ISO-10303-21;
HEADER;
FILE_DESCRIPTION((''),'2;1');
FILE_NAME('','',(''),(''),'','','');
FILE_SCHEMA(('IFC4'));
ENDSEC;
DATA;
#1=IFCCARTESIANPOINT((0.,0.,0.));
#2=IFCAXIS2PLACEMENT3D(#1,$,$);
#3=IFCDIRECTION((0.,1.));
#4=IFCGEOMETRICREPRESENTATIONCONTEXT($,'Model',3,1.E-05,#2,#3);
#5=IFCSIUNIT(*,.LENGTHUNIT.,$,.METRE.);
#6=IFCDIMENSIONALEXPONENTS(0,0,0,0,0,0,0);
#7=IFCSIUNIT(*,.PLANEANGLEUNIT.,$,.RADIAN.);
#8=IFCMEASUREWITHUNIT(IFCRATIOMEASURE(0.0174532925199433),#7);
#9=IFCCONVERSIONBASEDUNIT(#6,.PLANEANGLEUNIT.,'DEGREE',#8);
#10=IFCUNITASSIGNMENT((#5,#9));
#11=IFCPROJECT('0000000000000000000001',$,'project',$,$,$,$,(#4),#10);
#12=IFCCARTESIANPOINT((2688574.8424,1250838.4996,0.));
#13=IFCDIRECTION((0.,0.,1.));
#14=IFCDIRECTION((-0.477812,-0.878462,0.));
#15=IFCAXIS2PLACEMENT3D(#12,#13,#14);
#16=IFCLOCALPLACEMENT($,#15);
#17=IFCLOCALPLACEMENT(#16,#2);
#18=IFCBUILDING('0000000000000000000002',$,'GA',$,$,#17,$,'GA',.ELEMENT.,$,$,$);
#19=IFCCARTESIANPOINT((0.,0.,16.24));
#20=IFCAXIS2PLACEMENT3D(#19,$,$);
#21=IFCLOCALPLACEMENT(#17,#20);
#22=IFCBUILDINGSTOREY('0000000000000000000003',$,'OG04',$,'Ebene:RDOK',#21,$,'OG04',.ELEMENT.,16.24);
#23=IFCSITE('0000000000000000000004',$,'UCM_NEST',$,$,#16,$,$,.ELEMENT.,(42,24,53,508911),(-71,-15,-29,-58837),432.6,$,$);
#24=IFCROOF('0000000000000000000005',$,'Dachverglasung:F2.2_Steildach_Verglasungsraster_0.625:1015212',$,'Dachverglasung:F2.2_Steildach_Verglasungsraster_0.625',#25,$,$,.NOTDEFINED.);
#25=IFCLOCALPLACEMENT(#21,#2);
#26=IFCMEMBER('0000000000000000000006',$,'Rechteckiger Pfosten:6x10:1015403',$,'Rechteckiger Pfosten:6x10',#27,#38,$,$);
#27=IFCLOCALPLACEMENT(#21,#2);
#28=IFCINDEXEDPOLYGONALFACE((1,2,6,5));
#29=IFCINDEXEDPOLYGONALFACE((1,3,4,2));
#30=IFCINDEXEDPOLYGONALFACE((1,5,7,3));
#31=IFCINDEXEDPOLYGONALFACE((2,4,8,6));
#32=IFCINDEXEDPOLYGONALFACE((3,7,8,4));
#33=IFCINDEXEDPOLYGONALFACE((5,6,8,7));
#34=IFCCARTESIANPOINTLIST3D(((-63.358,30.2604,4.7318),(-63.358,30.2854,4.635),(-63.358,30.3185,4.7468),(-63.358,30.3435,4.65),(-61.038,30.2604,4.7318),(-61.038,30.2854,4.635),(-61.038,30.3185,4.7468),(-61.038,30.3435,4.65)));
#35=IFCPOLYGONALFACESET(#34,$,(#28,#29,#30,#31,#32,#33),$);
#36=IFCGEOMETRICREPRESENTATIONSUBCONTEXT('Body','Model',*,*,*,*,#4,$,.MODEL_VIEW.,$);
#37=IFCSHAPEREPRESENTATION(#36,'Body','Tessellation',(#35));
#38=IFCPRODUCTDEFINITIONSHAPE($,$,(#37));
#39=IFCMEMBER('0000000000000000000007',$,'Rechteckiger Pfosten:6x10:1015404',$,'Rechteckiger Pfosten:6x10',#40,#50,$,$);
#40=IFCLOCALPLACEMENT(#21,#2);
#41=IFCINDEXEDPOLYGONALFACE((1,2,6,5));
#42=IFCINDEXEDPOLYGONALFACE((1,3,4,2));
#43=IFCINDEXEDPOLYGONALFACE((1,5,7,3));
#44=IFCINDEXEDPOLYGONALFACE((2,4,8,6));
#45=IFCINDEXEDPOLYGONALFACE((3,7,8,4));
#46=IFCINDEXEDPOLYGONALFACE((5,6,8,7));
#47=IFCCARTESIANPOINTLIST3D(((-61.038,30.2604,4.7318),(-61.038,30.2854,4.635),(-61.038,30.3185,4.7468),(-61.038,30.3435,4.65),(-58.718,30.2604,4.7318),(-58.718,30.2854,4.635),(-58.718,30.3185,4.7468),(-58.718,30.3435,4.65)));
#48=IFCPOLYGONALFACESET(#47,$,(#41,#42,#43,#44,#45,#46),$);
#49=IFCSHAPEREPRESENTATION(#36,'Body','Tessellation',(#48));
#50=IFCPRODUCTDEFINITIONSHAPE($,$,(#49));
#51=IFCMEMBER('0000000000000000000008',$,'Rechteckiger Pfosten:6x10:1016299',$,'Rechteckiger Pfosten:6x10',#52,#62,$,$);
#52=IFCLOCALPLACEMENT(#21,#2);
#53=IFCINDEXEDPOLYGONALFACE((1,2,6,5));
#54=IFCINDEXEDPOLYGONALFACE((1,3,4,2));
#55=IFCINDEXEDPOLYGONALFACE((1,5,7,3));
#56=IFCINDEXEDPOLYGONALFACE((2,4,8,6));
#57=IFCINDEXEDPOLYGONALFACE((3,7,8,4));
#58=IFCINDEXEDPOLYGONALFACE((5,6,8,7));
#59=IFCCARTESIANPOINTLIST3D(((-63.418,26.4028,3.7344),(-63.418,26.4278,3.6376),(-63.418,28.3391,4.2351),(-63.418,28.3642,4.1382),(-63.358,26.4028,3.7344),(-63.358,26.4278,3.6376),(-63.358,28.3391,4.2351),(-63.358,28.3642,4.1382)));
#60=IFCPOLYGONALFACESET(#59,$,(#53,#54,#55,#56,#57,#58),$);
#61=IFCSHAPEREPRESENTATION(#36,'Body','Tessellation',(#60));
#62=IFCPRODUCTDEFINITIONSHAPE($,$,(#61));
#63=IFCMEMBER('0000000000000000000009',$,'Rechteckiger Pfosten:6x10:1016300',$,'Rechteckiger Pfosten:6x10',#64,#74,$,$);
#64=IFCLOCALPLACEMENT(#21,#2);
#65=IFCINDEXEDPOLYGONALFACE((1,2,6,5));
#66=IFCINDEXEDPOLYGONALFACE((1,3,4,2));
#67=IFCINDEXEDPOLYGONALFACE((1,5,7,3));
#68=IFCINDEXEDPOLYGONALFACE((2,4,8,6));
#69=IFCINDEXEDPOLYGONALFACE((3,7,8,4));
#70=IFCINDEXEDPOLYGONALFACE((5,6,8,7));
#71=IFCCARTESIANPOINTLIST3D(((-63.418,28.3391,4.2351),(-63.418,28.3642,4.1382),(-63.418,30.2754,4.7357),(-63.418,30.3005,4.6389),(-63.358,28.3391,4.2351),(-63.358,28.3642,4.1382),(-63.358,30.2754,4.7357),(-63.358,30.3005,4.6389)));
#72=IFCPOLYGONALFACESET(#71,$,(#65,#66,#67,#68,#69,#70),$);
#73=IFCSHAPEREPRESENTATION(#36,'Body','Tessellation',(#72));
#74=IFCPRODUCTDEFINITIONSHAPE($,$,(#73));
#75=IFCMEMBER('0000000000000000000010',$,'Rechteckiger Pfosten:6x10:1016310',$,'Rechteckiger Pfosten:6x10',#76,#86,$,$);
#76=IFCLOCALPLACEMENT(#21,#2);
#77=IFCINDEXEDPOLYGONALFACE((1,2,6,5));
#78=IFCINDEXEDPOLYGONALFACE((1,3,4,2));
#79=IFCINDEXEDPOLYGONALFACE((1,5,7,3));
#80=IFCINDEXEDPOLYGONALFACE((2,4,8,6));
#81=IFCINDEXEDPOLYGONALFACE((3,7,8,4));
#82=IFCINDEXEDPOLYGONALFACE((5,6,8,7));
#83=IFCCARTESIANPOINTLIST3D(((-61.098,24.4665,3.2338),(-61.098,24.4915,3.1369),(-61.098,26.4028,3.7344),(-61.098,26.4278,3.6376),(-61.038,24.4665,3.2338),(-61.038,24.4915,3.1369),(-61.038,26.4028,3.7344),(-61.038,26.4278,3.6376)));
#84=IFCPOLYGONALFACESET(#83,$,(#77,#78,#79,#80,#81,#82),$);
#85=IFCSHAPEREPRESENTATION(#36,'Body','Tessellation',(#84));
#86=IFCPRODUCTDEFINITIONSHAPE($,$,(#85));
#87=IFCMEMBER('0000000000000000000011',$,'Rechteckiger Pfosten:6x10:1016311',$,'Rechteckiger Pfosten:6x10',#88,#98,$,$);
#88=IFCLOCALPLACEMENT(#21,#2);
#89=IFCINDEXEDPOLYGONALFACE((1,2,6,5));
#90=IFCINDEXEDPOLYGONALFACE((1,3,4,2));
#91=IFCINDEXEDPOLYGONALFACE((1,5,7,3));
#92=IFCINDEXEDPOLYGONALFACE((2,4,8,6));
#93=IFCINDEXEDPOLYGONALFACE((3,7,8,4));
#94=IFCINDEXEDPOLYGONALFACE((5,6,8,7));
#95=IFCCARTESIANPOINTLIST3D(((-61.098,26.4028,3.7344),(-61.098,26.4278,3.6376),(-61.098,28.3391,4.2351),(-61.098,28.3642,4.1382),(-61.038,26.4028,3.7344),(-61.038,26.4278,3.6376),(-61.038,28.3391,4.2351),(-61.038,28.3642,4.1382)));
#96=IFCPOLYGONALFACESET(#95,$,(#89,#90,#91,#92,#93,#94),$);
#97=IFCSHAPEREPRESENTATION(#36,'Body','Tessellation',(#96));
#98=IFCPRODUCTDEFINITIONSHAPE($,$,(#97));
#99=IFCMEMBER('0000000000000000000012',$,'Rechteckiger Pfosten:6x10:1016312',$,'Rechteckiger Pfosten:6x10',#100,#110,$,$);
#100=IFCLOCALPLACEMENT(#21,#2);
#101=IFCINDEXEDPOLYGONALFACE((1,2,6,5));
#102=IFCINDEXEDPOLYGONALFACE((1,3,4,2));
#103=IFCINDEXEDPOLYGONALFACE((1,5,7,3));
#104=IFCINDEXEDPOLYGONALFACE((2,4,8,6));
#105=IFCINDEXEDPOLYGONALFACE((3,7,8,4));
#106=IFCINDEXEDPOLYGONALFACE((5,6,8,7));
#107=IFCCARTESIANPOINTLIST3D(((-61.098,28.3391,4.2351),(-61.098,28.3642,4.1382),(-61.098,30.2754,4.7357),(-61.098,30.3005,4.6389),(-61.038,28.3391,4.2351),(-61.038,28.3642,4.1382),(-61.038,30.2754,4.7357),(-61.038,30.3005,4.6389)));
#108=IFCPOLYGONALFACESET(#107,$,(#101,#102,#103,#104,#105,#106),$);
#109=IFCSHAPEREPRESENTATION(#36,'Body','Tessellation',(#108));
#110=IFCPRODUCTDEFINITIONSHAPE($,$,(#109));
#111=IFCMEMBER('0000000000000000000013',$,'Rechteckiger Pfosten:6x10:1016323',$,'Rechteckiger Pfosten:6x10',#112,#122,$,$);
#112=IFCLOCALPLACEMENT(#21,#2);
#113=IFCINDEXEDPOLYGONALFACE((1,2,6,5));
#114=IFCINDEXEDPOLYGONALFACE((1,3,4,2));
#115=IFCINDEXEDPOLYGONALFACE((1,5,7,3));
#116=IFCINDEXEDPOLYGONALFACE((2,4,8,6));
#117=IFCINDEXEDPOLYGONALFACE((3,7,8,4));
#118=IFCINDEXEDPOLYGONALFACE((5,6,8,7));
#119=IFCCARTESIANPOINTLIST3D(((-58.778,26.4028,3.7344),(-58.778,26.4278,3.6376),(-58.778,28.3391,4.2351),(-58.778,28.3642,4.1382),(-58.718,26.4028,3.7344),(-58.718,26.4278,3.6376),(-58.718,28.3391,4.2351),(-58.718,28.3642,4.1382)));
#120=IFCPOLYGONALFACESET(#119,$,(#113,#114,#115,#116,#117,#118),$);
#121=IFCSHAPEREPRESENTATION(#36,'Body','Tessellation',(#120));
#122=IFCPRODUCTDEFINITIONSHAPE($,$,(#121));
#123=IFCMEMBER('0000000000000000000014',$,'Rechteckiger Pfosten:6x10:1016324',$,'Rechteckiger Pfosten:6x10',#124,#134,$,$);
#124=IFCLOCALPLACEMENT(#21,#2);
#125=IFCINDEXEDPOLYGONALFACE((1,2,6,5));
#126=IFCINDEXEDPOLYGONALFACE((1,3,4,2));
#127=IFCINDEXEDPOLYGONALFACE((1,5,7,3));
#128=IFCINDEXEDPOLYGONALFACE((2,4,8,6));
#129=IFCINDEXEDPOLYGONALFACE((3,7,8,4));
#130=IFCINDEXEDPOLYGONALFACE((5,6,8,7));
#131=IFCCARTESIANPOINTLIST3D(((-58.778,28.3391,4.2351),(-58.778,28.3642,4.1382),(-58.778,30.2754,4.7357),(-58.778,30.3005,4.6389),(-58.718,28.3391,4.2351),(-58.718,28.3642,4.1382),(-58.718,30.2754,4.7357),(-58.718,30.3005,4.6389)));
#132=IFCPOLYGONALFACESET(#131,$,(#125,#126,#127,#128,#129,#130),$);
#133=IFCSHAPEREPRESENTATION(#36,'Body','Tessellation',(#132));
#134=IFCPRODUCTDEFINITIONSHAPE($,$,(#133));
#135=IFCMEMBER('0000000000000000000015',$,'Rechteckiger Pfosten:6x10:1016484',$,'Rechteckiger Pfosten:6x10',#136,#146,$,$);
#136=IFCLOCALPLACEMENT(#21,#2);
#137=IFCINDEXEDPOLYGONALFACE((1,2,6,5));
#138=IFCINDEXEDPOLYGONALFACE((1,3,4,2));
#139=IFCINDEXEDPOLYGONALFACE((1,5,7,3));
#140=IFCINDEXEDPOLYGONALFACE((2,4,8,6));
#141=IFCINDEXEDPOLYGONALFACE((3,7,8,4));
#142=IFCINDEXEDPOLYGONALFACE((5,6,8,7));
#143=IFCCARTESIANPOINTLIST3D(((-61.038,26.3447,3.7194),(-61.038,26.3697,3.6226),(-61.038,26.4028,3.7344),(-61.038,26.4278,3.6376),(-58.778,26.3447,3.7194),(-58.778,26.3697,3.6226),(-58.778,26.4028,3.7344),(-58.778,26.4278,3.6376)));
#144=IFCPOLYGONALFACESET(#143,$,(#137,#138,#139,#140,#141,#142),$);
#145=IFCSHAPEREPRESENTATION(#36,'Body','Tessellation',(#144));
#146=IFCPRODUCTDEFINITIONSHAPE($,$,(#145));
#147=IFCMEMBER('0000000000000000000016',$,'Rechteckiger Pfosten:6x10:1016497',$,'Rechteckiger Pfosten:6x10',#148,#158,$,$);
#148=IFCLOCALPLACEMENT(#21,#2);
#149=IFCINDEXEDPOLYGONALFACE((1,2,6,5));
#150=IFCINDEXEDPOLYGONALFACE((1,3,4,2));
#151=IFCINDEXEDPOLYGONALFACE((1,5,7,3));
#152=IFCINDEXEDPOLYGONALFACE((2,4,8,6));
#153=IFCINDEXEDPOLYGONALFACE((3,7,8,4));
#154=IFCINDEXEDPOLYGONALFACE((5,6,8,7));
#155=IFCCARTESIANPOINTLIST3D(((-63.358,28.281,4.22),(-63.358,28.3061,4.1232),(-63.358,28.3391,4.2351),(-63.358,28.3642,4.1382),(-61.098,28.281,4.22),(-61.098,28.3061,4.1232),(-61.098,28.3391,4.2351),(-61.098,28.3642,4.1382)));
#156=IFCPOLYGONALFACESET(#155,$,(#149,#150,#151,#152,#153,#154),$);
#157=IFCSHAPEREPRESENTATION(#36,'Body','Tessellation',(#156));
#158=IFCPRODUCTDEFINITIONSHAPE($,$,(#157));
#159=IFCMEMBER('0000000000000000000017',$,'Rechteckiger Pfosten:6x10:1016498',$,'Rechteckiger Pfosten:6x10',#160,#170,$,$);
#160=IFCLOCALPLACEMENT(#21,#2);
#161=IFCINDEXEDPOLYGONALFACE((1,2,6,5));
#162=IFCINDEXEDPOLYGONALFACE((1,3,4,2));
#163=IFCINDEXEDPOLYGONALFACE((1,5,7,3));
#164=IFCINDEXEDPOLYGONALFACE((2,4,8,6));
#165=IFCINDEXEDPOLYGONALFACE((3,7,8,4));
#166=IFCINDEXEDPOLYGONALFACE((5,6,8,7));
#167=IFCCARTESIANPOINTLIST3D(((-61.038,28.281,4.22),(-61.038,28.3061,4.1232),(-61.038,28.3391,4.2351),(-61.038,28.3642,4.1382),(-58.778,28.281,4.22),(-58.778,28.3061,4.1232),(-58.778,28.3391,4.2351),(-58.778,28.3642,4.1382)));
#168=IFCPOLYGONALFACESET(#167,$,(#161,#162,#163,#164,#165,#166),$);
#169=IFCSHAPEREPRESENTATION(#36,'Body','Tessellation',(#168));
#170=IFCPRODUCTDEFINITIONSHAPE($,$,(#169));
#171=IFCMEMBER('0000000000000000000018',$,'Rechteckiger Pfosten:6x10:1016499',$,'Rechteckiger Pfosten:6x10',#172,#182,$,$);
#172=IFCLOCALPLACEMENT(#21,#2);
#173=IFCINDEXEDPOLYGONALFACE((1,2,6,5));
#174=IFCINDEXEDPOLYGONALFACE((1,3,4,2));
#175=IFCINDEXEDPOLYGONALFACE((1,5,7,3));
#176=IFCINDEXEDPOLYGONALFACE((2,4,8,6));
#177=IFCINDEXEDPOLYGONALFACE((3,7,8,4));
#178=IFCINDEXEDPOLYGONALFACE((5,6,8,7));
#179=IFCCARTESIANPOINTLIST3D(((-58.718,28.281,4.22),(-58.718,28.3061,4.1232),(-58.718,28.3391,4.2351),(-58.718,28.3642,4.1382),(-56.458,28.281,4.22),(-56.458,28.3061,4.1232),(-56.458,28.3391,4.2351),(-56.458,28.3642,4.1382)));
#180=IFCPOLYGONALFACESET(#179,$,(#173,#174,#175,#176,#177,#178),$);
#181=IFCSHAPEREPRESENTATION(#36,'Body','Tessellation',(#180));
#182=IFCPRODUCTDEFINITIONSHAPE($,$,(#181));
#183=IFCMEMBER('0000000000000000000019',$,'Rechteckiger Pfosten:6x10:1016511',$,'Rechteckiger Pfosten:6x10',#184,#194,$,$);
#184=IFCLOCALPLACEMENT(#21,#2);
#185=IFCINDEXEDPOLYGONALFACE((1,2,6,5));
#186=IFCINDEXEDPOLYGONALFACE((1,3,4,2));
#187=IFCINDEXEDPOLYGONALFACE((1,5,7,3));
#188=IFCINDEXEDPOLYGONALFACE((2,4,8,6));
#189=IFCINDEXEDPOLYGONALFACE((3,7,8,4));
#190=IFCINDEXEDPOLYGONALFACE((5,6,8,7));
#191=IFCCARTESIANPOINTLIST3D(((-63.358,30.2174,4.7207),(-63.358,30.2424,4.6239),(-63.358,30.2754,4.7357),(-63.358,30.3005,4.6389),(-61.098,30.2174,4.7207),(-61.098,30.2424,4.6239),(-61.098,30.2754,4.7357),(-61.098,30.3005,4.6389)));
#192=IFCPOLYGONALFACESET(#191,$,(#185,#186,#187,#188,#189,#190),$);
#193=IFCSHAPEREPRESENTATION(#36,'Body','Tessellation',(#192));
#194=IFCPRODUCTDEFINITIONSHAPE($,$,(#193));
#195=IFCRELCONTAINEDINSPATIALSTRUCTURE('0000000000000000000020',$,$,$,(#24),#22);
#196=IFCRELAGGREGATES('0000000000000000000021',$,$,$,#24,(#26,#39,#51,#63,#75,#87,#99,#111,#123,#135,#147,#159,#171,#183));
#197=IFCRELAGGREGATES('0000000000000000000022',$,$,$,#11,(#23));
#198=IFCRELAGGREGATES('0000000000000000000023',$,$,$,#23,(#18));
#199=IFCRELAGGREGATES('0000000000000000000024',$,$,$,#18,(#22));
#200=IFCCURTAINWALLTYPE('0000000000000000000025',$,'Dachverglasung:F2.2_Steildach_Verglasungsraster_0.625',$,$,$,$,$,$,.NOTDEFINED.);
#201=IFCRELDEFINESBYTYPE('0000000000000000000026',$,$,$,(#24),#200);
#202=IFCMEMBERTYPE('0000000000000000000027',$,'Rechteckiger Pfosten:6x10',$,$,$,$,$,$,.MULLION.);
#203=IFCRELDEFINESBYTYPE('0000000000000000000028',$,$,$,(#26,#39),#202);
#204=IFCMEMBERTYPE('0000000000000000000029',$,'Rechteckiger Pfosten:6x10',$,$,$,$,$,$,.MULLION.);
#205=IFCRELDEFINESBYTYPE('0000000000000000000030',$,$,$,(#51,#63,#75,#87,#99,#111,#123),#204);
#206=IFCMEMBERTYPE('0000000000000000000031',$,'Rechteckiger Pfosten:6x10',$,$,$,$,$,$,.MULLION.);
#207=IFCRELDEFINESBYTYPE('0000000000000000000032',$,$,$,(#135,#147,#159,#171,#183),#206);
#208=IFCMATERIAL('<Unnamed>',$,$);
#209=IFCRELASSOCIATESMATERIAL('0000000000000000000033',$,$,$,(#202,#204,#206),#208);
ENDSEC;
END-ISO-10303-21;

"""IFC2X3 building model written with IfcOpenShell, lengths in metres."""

from ifc_helpers import new_model, entity, si_unit, converted_unit, direction, frame, origin, origin_2d_with_axis, place, context, subcontext, project, spatial, rectangle, extrude, source, transform, mapped, material, type_object, type_shapes, element, aggregate, save


model = new_model("IFC2X3")

# Units and contexts
model_context = context("Model", 3, precision=1e-05, world=origin(), true_north=direction((0.0, 1.0)))
body_context = subcontext(model_context, "Body", "Model", "MODEL_VIEW")
ifc_project = project(units=[si_unit("LENGTHUNIT", "METRE"), converted_unit("PLANEANGLEUNIT", "DEGREE", entity("IfcRatioMeasure", 0.0174532925199433), si_unit("PLANEANGLEUNIT", "RADIAN"), dimensions=[0, 0, 0, 0, 0, 0, 0])], contexts=[model_context])

# Site, building, storey
site_placement = place(None, frame((2688574.8424, 1250838.4996, 0.0), z_axis=(0.0, 0.0, 1.0), x_axis=(-0.477812, -0.878462, 0.0)))
site = spatial("IfcSite", under=ifc_project, at=site_placement, Name="UCM_NEST", CompositionType="ELEMENT", RefLatitude=(42, 24, 53, 508911), RefLongitude=(-71, -15, -29, -58837), RefElevation=432.6)
building_placement = place(site_placement, origin())
building = spatial("IfcBuilding", under=site, at=building_placement, Name="GA", LongName="GA", CompositionType="ELEMENT")
storey_placement = place(building_placement, frame((0.0, 0.0, 16.24)))
storey = spatial("IfcBuildingStorey", under=building, at=storey_placement, Name="OG04", ObjectType="Ebene:RDOK", LongName="OG04", CompositionType="ELEMENT", Elevation=16.24)

# Roof, members
curtain_wall_type = type_object("IfcCurtainWallType", Name="Dachverglasung:F2.2_Steildach_Verglasungsraster_0.625", PredefinedType="NOTDEFINED")
roof_placement = place(storey_placement, frame((0.0, 0.0, -16.24)))
roof = element("IfcRoof", 1, at=roof_placement, inside=storey, type_object=curtain_wall_type, Name="Dachverglasung:F2.2_Steildach_Verglasungsraster_0.625:1015212", ObjectType="Dachverglasung:F2.2_Steildach_Verglasungsraster_0.625", ShapeType="NOTDEFINED")
ifc_material_1 = material(Name="<Unnamed>")
member_type_1 = type_object("IfcMemberType", Name="Rechteckiger Pfosten:6x10", PredefinedType="MULLION", material=ifc_material_1)
shared_shape_1 = source(origin(), body_context, "Body", "SweptSolid", [
    extrude(rectangle(XDim=0.1, YDim=0.06, at=origin_2d_with_axis()), frame((-0.03, -0.05, -2.32), z_axis=(0.0, 0.0, 1.0), x_axis=(0.0, -1.0, 0.0)), (0.0, 0.0, 1.0), 2.32),
])
type_shapes(member_type_1, [shared_shape_1])
member_1_placement = place(roof_placement, frame((-63.358, 30.3435, 20.89), z_axis=(-1.0, 0.0, 0.0), x_axis=(0.0, 0.968163, 0.250322)))
member_1 = element("IfcMember", 2, at=member_1_placement, type_object=member_type_1, Name="Rechteckiger Pfosten:6x10:1015403", ObjectType="Rechteckiger Pfosten:6x10", context=body_context, shape_type="MappedRepresentation", body=[
    mapped(shared_shape_1, transform((0.0, 0.0, 0.0), scale=1.0)),
])
member_2_placement = place(roof_placement, frame((-61.038, 30.3435, 20.89), z_axis=(-1.0, 0.0, 0.0), x_axis=(0.0, 0.968163, 0.250322)))
member_2 = element("IfcMember", 3, at=member_2_placement, type_object=member_type_1, Name="Rechteckiger Pfosten:6x10:1015404", ObjectType="Rechteckiger Pfosten:6x10", context=body_context, shape_type="MappedRepresentation", body=[
    mapped(shared_shape_1, transform((0.0, 0.0, 0.0), scale=1.0)),
])
member_type_2 = type_object("IfcMemberType", Name="Rechteckiger Pfosten:6x10", PredefinedType="MULLION", material=ifc_material_1)
shared_shape_2 = source(origin(), body_context, "Body", "SweptSolid", [
    extrude(rectangle(XDim=0.1, YDim=0.06, at=origin_2d_with_axis()), frame((-0.03, -0.05, -2.0), z_axis=(0.0, 0.0, 1.0), x_axis=(0.0, -1.0, 0.0)), (0.0, 0.0, 1.0), 2.0),
])
type_shapes(member_type_2, [shared_shape_2])
member_3_placement = place(roof_placement, frame((-63.358, 28.3642, 20.3782), z_axis=(0.0, 0.968163, 0.250322), x_axis=(1.0, 0.0, 0.0)))
member_3 = element("IfcMember", 4, at=member_3_placement, type_object=member_type_2, Name="Rechteckiger Pfosten:6x10:1016299", ObjectType="Rechteckiger Pfosten:6x10", context=body_context, shape_type="MappedRepresentation", body=[
    mapped(shared_shape_2, transform((0.0, 0.0, 0.0), scale=1.0)),
])
member_4_placement = place(roof_placement, frame((-63.358, 30.3005, 20.8789), z_axis=(0.0, 0.968163, 0.250322), x_axis=(1.0, 0.0, 0.0)))
member_4 = element("IfcMember", 5, at=member_4_placement, type_object=member_type_2, Name="Rechteckiger Pfosten:6x10:1016300", ObjectType="Rechteckiger Pfosten:6x10", context=body_context, shape_type="MappedRepresentation", body=[
    mapped(shared_shape_2, transform((0.0, 0.0, 0.0), scale=1.0)),
])
member_5_placement = place(roof_placement, frame((-61.038, 26.4278, 19.8776), z_axis=(0.0, 0.968163, 0.250322), x_axis=(1.0, 0.0, 0.0)))
member_5 = element("IfcMember", 6, at=member_5_placement, type_object=member_type_2, Name="Rechteckiger Pfosten:6x10:1016310", ObjectType="Rechteckiger Pfosten:6x10", context=body_context, shape_type="MappedRepresentation", body=[
    mapped(shared_shape_2, transform((0.0, 0.0, 0.0), scale=1.0)),
])
member_6_placement = place(roof_placement, frame((-61.038, 28.3642, 20.3782), z_axis=(0.0, 0.968163, 0.250322), x_axis=(1.0, 0.0, 0.0)))
member_6 = element("IfcMember", 7, at=member_6_placement, type_object=member_type_2, Name="Rechteckiger Pfosten:6x10:1016311", ObjectType="Rechteckiger Pfosten:6x10", context=body_context, shape_type="MappedRepresentation", body=[
    mapped(shared_shape_2, transform((0.0, 0.0, 0.0), scale=1.0)),
])
member_7_placement = place(roof_placement, frame((-61.038, 30.3005, 20.8789), z_axis=(0.0, 0.968163, 0.250322), x_axis=(1.0, 0.0, 0.0)))
member_7 = element("IfcMember", 8, at=member_7_placement, type_object=member_type_2, Name="Rechteckiger Pfosten:6x10:1016312", ObjectType="Rechteckiger Pfosten:6x10", context=body_context, shape_type="MappedRepresentation", body=[
    mapped(shared_shape_2, transform((0.0, 0.0, 0.0), scale=1.0)),
])
member_8_placement = place(roof_placement, frame((-58.718, 28.3642, 20.3782), z_axis=(0.0, 0.968163, 0.250322), x_axis=(1.0, 0.0, 0.0)))
member_8 = element("IfcMember", 9, at=member_8_placement, type_object=member_type_2, Name="Rechteckiger Pfosten:6x10:1016323", ObjectType="Rechteckiger Pfosten:6x10", context=body_context, shape_type="MappedRepresentation", body=[
    mapped(shared_shape_2, transform((0.0, 0.0, 0.0), scale=1.0)),
])
member_9_placement = place(roof_placement, frame((-58.718, 30.3005, 20.8789), z_axis=(0.0, 0.968163, 0.250322), x_axis=(1.0, 0.0, 0.0)))
member_9 = element("IfcMember", 10, at=member_9_placement, type_object=member_type_2, Name="Rechteckiger Pfosten:6x10:1016324", ObjectType="Rechteckiger Pfosten:6x10", context=body_context, shape_type="MappedRepresentation", body=[
    mapped(shared_shape_2, transform((0.0, 0.0, 0.0), scale=1.0)),
])
member_type_3 = type_object("IfcMemberType", Name="Rechteckiger Pfosten:6x10", PredefinedType="MULLION", material=ifc_material_1)
shared_shape_3 = source(origin(), body_context, "Body", "SweptSolid", [
    extrude(rectangle(XDim=0.1, YDim=0.06, at=origin_2d_with_axis()), frame((-0.03, -0.05, -2.26), z_axis=(0.0, 0.0, 1.0), x_axis=(0.0, -1.0, 0.0)), (0.0, 0.0, 1.0), 2.26),
])
type_shapes(member_type_3, [shared_shape_3])
member_10_placement = place(roof_placement, frame((-61.038, 26.4278, 19.8776), z_axis=(-1.0, 0.0, 0.0), x_axis=(0.0, 0.968163, 0.250322)))
member_10 = element("IfcMember", 11, at=member_10_placement, type_object=member_type_3, Name="Rechteckiger Pfosten:6x10:1016484", ObjectType="Rechteckiger Pfosten:6x10", context=body_context, shape_type="MappedRepresentation", body=[
    mapped(shared_shape_3, transform((0.0, 0.0, 0.0), scale=1.0)),
])
member_11_placement = place(roof_placement, frame((-63.358, 28.3642, 20.3782), z_axis=(-1.0, 0.0, 0.0), x_axis=(0.0, 0.968163, 0.250322)))
member_11 = element("IfcMember", 12, at=member_11_placement, type_object=member_type_3, Name="Rechteckiger Pfosten:6x10:1016497", ObjectType="Rechteckiger Pfosten:6x10", context=body_context, shape_type="MappedRepresentation", body=[
    mapped(shared_shape_3, transform((0.0, 0.0, 0.0), scale=1.0)),
])
member_12_placement = place(roof_placement, frame((-61.038, 28.3642, 20.3782), z_axis=(-1.0, 0.0, 0.0), x_axis=(0.0, 0.968163, 0.250322)))
member_12 = element("IfcMember", 13, at=member_12_placement, type_object=member_type_3, Name="Rechteckiger Pfosten:6x10:1016498", ObjectType="Rechteckiger Pfosten:6x10", context=body_context, shape_type="MappedRepresentation", body=[
    mapped(shared_shape_3, transform((0.0, 0.0, 0.0), scale=1.0)),
])
member_13_placement = place(roof_placement, frame((-58.718, 28.3642, 20.3782), z_axis=(-1.0, 0.0, 0.0), x_axis=(0.0, 0.968163, 0.250322)))
member_13 = element("IfcMember", 14, at=member_13_placement, type_object=member_type_3, Name="Rechteckiger Pfosten:6x10:1016499", ObjectType="Rechteckiger Pfosten:6x10", context=body_context, shape_type="MappedRepresentation", body=[
    mapped(shared_shape_3, transform((0.0, 0.0, 0.0), scale=1.0)),
])
member_14_placement = place(roof_placement, frame((-63.358, 30.3005, 20.8789), z_axis=(-1.0, 0.0, 0.0), x_axis=(0.0, 0.968163, 0.250322)))
member_14 = element("IfcMember", 15, at=member_14_placement, type_object=member_type_3, Name="Rechteckiger Pfosten:6x10:1016511", ObjectType="Rechteckiger Pfosten:6x10", context=body_context, shape_type="MappedRepresentation", body=[
    mapped(shared_shape_3, transform((0.0, 0.0, 0.0), scale=1.0)),
])
aggregate(roof, [member_1, member_2, member_3, member_4, member_5, member_6, member_7, member_8, member_9, member_10, member_11, member_12, member_13, member_14])

save(model, "model.ifc")
